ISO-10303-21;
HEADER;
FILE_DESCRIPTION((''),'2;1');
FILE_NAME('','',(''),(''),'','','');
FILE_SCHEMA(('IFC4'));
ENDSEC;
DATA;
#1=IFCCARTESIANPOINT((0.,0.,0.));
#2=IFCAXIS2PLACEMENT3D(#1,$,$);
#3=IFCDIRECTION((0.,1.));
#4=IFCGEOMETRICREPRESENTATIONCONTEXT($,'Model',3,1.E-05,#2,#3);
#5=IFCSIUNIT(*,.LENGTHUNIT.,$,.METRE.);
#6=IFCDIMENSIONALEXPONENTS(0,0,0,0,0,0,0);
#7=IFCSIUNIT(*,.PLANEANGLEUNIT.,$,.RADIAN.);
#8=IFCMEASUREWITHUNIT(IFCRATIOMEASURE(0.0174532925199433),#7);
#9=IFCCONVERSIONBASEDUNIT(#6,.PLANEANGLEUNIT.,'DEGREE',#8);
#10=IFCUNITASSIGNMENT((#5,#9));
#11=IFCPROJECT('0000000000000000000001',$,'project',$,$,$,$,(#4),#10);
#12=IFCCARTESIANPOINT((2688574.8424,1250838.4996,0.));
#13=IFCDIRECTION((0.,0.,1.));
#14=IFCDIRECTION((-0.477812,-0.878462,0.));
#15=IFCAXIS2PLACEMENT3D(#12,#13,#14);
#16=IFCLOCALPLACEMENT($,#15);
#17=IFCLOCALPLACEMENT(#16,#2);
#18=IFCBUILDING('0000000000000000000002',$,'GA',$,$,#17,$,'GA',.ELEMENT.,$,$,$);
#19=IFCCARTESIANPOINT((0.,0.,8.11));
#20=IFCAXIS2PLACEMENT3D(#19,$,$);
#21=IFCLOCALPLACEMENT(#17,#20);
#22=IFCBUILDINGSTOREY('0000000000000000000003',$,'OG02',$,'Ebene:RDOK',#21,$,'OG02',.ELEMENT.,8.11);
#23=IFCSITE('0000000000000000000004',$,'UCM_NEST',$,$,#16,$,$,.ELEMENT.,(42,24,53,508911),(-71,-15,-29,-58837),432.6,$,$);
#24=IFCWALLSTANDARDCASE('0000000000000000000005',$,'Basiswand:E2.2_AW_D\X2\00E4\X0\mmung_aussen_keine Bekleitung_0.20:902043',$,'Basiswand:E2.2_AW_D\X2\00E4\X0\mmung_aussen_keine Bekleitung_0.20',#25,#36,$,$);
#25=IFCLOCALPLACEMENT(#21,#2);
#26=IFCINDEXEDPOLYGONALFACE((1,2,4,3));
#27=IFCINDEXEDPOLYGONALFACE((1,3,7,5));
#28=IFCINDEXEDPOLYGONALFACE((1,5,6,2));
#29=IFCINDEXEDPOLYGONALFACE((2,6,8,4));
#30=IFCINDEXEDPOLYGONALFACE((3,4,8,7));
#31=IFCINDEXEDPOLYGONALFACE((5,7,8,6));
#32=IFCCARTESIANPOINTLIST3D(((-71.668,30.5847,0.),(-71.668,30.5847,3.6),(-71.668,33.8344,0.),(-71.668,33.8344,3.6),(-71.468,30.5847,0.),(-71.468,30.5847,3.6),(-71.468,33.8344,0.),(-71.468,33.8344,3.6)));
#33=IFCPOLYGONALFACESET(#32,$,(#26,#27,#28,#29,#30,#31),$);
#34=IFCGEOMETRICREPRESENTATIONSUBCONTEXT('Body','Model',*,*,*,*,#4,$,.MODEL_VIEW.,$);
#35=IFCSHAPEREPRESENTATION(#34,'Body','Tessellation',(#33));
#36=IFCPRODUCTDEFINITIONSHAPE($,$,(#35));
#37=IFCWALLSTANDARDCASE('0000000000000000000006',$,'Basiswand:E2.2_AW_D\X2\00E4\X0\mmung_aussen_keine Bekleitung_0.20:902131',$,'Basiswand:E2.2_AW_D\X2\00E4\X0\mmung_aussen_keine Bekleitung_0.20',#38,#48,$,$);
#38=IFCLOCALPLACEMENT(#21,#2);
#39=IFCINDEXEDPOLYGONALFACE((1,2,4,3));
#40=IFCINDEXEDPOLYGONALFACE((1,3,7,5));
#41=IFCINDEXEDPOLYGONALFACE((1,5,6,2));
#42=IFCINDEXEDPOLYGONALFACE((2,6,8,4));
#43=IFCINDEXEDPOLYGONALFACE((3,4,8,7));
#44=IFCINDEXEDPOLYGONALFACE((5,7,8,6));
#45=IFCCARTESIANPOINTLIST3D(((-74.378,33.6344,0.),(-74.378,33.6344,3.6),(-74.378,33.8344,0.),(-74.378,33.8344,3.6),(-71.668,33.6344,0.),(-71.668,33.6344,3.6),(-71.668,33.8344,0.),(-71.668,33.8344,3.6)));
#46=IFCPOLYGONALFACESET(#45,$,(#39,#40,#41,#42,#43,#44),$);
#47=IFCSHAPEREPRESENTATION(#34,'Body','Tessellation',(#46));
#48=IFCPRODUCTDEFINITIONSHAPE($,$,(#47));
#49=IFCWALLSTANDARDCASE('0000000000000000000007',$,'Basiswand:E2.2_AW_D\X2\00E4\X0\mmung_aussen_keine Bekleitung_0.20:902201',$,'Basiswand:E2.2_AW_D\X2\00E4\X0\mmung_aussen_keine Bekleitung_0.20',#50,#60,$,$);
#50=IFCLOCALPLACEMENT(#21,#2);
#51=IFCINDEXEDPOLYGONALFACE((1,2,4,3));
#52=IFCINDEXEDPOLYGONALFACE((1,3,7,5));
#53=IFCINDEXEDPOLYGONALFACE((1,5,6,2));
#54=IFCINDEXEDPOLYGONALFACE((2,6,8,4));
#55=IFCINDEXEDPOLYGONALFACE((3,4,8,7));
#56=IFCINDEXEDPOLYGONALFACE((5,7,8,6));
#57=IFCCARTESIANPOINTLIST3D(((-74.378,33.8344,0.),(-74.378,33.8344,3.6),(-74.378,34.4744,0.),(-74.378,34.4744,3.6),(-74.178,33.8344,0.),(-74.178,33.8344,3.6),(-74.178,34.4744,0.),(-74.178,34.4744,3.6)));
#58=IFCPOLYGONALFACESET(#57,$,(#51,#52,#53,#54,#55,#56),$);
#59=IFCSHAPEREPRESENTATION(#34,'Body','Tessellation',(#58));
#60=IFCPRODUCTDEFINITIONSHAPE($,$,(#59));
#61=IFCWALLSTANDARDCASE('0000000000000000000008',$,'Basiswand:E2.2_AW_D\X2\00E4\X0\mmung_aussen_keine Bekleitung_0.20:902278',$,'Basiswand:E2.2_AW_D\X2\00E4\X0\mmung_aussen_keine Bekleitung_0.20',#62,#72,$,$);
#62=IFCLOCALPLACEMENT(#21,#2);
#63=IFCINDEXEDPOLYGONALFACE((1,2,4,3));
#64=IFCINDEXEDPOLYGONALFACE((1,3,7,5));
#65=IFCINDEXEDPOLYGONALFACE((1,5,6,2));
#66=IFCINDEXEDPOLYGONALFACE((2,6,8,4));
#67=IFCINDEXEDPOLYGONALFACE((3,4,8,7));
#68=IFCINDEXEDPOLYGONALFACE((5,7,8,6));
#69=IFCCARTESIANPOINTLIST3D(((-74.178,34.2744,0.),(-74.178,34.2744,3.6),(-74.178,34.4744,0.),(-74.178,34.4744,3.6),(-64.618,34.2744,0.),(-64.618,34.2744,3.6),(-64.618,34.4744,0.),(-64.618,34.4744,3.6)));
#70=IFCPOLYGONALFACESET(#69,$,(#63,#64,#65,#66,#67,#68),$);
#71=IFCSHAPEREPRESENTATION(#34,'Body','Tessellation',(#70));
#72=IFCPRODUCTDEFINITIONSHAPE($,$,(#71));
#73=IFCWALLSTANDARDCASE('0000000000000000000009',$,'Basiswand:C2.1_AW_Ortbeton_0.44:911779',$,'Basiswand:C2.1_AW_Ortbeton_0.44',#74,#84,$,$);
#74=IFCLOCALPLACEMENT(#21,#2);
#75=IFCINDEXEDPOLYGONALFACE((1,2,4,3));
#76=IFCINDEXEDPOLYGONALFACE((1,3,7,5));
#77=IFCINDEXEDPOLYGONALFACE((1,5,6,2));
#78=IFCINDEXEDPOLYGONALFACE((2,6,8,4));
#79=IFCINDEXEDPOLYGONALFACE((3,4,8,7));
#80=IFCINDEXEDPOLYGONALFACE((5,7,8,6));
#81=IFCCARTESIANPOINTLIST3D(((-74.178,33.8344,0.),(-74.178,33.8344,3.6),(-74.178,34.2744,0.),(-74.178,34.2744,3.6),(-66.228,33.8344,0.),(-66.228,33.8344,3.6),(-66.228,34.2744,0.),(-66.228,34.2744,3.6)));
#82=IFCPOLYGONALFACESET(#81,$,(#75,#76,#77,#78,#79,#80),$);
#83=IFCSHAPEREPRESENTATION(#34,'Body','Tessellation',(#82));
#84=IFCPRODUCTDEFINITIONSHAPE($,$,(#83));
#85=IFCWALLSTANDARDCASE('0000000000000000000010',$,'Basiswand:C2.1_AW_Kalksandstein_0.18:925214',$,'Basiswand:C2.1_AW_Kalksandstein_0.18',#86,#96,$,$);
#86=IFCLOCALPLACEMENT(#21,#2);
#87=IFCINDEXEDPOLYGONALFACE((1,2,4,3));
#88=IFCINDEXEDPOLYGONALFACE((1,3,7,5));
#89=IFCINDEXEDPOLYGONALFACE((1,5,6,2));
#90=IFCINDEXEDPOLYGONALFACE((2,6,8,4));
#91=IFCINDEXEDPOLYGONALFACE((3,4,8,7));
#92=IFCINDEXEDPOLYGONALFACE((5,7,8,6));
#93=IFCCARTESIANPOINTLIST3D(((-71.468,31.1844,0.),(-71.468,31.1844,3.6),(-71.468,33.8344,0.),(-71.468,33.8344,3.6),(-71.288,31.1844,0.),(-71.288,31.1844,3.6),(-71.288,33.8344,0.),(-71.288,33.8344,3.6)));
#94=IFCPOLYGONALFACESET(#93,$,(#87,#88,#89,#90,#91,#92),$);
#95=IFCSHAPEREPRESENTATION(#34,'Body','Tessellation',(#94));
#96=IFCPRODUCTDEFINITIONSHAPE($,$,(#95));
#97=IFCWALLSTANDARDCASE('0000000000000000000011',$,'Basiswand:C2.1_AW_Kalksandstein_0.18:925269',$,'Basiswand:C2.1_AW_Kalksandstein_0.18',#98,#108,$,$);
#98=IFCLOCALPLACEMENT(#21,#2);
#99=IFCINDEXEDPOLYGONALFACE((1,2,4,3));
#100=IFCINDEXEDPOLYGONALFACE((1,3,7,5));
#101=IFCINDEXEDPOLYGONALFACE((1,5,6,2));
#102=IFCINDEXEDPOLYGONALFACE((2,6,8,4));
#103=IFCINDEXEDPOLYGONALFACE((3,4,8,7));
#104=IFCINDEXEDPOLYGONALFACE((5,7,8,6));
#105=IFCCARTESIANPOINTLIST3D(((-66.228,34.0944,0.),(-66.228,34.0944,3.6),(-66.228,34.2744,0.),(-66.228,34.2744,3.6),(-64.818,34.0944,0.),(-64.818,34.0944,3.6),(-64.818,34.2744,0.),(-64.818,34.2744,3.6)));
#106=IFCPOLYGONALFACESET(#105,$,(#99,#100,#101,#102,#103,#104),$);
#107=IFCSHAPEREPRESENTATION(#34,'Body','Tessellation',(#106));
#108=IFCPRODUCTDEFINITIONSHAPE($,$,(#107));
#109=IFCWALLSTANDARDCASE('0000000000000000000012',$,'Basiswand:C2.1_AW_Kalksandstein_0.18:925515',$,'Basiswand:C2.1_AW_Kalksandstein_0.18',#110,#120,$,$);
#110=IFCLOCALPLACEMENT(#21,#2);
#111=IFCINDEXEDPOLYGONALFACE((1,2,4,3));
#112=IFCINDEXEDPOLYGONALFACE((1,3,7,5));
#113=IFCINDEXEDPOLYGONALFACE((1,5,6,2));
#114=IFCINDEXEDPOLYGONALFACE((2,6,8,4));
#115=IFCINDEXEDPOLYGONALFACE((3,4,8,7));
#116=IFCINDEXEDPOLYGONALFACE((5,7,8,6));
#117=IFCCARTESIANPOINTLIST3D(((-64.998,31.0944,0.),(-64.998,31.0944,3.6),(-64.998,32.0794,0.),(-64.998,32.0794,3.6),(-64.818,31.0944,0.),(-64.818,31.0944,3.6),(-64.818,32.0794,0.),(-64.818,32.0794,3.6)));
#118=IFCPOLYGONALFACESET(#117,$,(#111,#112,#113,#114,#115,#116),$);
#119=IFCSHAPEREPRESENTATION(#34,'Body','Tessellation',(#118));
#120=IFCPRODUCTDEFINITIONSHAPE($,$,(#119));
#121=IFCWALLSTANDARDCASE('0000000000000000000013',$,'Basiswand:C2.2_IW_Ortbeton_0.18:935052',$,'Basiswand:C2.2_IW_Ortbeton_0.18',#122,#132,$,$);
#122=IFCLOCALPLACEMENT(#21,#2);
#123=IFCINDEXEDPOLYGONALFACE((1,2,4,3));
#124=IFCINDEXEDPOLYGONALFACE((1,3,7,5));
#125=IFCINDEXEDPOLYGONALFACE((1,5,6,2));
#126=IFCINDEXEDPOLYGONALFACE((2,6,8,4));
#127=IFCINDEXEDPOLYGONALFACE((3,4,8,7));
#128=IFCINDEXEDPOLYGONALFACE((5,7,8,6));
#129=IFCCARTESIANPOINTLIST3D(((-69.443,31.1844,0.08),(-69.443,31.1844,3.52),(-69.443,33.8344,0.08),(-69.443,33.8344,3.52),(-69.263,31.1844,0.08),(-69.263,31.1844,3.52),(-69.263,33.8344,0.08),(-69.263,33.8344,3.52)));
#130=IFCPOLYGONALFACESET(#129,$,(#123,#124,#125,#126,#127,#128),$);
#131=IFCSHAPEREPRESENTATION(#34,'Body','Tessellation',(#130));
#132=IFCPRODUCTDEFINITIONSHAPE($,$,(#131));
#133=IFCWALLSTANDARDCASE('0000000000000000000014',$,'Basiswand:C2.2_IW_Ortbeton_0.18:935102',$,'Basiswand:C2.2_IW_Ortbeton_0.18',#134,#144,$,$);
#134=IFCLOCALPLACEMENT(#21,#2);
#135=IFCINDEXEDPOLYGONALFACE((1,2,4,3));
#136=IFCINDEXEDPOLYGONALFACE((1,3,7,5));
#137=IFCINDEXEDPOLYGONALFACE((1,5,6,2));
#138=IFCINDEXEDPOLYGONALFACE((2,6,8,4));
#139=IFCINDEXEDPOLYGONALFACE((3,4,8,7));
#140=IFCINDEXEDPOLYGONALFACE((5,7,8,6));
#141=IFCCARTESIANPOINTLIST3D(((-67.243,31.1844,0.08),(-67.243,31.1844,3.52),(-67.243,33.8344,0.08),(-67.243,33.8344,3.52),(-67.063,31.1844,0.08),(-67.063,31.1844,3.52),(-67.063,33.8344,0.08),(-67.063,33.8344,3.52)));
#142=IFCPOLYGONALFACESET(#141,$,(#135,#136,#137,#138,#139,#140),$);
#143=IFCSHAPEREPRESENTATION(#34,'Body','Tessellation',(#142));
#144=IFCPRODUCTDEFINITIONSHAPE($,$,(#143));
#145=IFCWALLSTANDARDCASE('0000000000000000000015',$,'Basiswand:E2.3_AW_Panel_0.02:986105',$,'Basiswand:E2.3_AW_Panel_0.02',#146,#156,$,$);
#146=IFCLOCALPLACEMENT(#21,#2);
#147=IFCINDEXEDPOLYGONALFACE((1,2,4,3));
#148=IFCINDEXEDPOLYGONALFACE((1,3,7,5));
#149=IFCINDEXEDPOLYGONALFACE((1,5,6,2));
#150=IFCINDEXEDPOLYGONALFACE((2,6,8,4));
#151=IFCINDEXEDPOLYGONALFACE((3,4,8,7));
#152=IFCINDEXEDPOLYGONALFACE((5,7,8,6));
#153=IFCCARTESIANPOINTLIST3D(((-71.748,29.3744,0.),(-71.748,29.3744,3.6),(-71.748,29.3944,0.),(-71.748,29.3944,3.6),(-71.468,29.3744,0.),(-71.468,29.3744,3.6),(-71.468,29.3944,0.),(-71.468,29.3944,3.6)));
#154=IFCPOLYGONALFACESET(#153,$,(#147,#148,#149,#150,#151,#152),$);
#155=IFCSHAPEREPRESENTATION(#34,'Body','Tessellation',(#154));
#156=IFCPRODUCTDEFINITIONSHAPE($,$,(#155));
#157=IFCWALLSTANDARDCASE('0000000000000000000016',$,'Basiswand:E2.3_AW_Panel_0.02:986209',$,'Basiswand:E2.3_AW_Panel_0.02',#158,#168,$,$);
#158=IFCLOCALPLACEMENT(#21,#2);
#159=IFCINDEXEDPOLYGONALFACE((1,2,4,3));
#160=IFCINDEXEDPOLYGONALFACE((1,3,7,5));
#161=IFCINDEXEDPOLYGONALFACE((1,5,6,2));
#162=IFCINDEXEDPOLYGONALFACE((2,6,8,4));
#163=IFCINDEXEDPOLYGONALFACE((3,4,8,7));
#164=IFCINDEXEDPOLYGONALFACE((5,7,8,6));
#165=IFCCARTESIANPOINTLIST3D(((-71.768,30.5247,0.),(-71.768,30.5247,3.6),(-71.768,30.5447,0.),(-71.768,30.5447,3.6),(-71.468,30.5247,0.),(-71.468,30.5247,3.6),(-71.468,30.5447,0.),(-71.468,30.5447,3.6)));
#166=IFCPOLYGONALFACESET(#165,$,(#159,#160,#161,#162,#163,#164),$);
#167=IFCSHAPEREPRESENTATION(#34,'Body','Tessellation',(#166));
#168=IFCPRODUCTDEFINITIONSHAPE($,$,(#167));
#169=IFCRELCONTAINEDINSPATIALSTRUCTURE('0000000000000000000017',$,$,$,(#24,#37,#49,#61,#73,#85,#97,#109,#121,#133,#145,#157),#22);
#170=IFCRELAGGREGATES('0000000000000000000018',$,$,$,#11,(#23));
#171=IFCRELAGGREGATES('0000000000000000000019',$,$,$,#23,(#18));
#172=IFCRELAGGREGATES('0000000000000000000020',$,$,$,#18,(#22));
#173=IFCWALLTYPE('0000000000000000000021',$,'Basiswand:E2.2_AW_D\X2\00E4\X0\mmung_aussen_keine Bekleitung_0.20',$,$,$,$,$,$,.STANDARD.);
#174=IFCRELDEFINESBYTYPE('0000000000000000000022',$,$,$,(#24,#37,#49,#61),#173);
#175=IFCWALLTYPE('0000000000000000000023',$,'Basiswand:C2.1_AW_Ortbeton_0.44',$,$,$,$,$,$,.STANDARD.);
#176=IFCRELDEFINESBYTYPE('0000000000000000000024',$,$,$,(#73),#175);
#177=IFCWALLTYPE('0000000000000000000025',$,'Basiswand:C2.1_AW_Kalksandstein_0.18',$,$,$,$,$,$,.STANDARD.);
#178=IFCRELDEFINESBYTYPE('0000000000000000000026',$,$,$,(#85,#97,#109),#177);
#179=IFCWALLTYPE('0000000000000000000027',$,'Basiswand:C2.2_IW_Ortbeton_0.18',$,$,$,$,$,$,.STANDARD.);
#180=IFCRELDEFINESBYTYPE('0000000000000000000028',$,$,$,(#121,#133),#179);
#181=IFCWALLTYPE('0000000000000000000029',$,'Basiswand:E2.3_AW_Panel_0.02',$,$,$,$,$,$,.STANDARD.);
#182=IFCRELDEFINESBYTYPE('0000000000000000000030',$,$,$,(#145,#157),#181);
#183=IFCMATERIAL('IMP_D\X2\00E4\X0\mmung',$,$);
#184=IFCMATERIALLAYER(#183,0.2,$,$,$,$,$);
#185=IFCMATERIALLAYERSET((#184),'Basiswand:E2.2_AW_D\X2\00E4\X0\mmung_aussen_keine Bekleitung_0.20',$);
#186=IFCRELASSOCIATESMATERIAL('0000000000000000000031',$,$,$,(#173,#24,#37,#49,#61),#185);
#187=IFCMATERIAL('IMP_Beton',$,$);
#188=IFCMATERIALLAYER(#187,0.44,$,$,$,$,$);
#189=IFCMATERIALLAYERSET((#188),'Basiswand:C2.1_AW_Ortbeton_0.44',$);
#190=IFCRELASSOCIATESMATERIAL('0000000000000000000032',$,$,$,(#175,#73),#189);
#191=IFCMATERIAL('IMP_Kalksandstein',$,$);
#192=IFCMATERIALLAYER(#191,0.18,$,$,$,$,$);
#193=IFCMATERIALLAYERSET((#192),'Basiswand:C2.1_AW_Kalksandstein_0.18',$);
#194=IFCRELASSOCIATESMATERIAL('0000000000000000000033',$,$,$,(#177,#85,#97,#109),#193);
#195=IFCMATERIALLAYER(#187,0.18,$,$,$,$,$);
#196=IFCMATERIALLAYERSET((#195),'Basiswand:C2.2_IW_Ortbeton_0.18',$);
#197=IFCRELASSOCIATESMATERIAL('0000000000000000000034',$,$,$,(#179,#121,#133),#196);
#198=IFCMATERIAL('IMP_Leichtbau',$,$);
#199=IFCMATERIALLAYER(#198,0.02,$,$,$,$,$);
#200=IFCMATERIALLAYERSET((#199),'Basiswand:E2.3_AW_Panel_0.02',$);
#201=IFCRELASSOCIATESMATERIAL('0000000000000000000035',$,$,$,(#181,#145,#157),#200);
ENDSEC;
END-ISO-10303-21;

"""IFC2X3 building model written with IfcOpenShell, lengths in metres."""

from ifc_helpers import new_model, entity, si_unit, converted_unit, direction, frame, frame_2d, origin, place, context, subcontext, project, spatial, polyline, rectangle, extrude, clip, bounded_halfspace, material, layer, layer_set, layer_usage, type_object, element, save


model = new_model("IFC2X3")

# Units and contexts
model_context = context("Model", 3, precision=1e-05, world=origin(), true_north=direction((0.0, 1.0)))
body_context = subcontext(model_context, "Body", "Model", "MODEL_VIEW")
ifc_project = project(units=[si_unit("LENGTHUNIT", "METRE"), converted_unit("PLANEANGLEUNIT", "DEGREE", entity("IfcRatioMeasure", 0.0174532925199433), si_unit("PLANEANGLEUNIT", "RADIAN"), dimensions=[0, 0, 0, 0, 0, 0, 0])], contexts=[model_context])

# Site, building, storey
site_placement = place(None, frame((2688574.8424, 1250838.4996, 0.0), z_axis=(0.0, 0.0, 1.0), x_axis=(-0.477812, -0.878462, 0.0)))
site = spatial("IfcSite", under=ifc_project, at=site_placement, Name="UCM_NEST", CompositionType="ELEMENT", RefLatitude=(42, 24, 53, 508911), RefLongitude=(-71, -15, -29, -58837), RefElevation=432.6)
building_placement = place(site_placement, origin())
building = spatial("IfcBuilding", under=site, at=building_placement, Name="GA", LongName="GA", CompositionType="ELEMENT")
storey_placement = place(building_placement, frame((0.0, 0.0, 8.11)))
storey = spatial("IfcBuildingStorey", under=building, at=storey_placement, Name="OG02", ObjectType="Ebene:RDOK", LongName="OG02", CompositionType="ELEMENT", Elevation=8.11)

# Walls
ifc_material_1 = material(Name="IMP_Dämmung")
ifc_layer_1 = layer(ifc_material_1, 0.2)
ifc_layer_set_1 = layer_set([ifc_layer_1], Name="Basiswand:E2.2_AW_Dämmung_aussen_keine Bekleitung_0.20")
ifc_layer_usage_1 = layer_usage(ifc_layer_set_1, "AXIS2", "NEGATIVE", 0.1)
wall_type_1 = type_object("IfcWallType", Name="Basiswand:E2.2_AW_Dämmung_aussen_keine Bekleitung_0.20", PredefinedType="STANDARD", material=ifc_layer_set_1)
wall_1_placement = place(storey_placement, frame((-71.568, 30.5847, 0.0), z_axis=(0.0, 0.0, 1.0), x_axis=(0.0, 1.0, 0.0)))
element("IfcWallStandardCase", 1, at=wall_1_placement, inside=storey, type_object=wall_type_1, material=ifc_layer_usage_1, Name="Basiswand:E2.2_AW_Dämmung_aussen_keine Bekleitung_0.20:902043", ObjectType="Basiswand:E2.2_AW_Dämmung_aussen_keine Bekleitung_0.20", context=body_context, shape_type="SweptSolid", body=[
    extrude(rectangle(XDim=3.2498, YDim=0.2, at=frame_2d((1.6249, 0.0), x_axis=(-1.0, 0.0))), origin(), (0.0, 0.0, 1.0), 3.6),
])
ifc_layer_usage_2 = layer_usage(ifc_layer_set_1, "AXIS2", "NEGATIVE", 0.1)
wall_2_placement = place(storey_placement, frame((-71.668, 33.7344, 0.0), z_axis=(0.0, 0.0, 1.0), x_axis=(-1.0, 0.0, 0.0)))
element("IfcWallStandardCase", 2, at=wall_2_placement, inside=storey, type_object=wall_type_1, material=ifc_layer_usage_2, Name="Basiswand:E2.2_AW_Dämmung_aussen_keine Bekleitung_0.20:902131", ObjectType="Basiswand:E2.2_AW_Dämmung_aussen_keine Bekleitung_0.20", context=body_context, shape_type="SweptSolid", body=[
    extrude(rectangle(XDim=2.71, YDim=0.2, at=frame_2d((1.355, 0.0), x_axis=(-1.0, 0.0))), origin(), (0.0, 0.0, 1.0), 3.6),
])
ifc_layer_usage_3 = layer_usage(ifc_layer_set_1, "AXIS2", "NEGATIVE", 0.1)
wall_3_placement = place(storey_placement, frame((-74.278, 33.8344, 0.0), z_axis=(0.0, 0.0, 1.0), x_axis=(0.0, 1.0, 0.0)))
element("IfcWallStandardCase", 3, at=wall_3_placement, inside=storey, type_object=wall_type_1, material=ifc_layer_usage_3, Name="Basiswand:E2.2_AW_Dämmung_aussen_keine Bekleitung_0.20:902201", ObjectType="Basiswand:E2.2_AW_Dämmung_aussen_keine Bekleitung_0.20", context=body_context, shape_type="SweptSolid", body=[
    extrude(rectangle(XDim=0.64, YDim=0.2, at=frame_2d((0.32, 0.0), x_axis=(-1.0, 0.0))), origin(), (0.0, 0.0, 1.0), 3.6),
])
ifc_layer_usage_4 = layer_usage(ifc_layer_set_1, "AXIS2", "NEGATIVE", 0.1)
wall_4_placement = place(storey_placement, frame((-74.178, 34.3744, 0.0)))
element("IfcWallStandardCase", 4, at=wall_4_placement, inside=storey, type_object=wall_type_1, material=ifc_layer_usage_4, Name="Basiswand:E2.2_AW_Dämmung_aussen_keine Bekleitung_0.20:902278", ObjectType="Basiswand:E2.2_AW_Dämmung_aussen_keine Bekleitung_0.20", context=body_context, shape_type="SweptSolid", body=[
    extrude(rectangle(XDim=9.56, YDim=0.2, at=frame_2d((4.78, 0.0), x_axis=(-1.0, 0.0))), origin(), (0.0, 0.0, 1.0), 3.6),
])
ifc_material_2 = material(Name="IMP_Beton")
ifc_layer_2 = layer(ifc_material_2, 0.44)
ifc_layer_set_2 = layer_set([ifc_layer_2], Name="Basiswand:C2.1_AW_Ortbeton_0.44")
ifc_layer_usage_5 = layer_usage(ifc_layer_set_2, "AXIS2", "NEGATIVE", 0.22)
wall_type_2 = type_object("IfcWallType", Name="Basiswand:C2.1_AW_Ortbeton_0.44", PredefinedType="STANDARD", material=ifc_layer_set_2)
wall_5_placement = place(storey_placement, frame((-74.178, 34.0544, 0.0)))
element("IfcWallStandardCase", 5, at=wall_5_placement, inside=storey, type_object=wall_type_2, material=ifc_layer_usage_5, Name="Basiswand:C2.1_AW_Ortbeton_0.44:911779", ObjectType="Basiswand:C2.1_AW_Ortbeton_0.44", context=body_context, shape_type="SweptSolid", body=[
    extrude(rectangle(XDim=7.95, YDim=0.44, at=frame_2d((3.975, 0.0), x_axis=(-1.0, 0.0))), origin(), (0.0, 0.0, 1.0), 3.6),
])

# Shared definitions
ifc_material_3 = material(Name="IMP_Kalksandstein")
ifc_layer_3 = layer(ifc_material_3, 0.18)
ifc_layer_set_3 = layer_set([ifc_layer_3], Name="Basiswand:C2.1_AW_Kalksandstein_0.18")
wall_type_3 = type_object("IfcWallType", Name="Basiswand:C2.1_AW_Kalksandstein_0.18", PredefinedType="STANDARD", material=ifc_layer_set_3)

# Walls
ifc_layer_usage_6 = layer_usage(ifc_layer_set_3, "AXIS2", "NEGATIVE", 0.09)
wall_6_placement = place(storey_placement, frame((-71.378, 31.1844, 0.0), z_axis=(0.0, 0.0, 1.0), x_axis=(0.0, 1.0, 0.0)))
element("IfcWallStandardCase", 6, at=wall_6_placement, inside=storey, type_object=wall_type_3, material=ifc_layer_usage_6, Name="Basiswand:C2.1_AW_Kalksandstein_0.18:925214", ObjectType="Basiswand:C2.1_AW_Kalksandstein_0.18", context=body_context, shape_type="SweptSolid", body=[
    extrude(rectangle(XDim=2.65, YDim=0.18, at=frame_2d((1.325, 0.0), x_axis=(-1.0, 0.0))), origin(), (0.0, 0.0, 1.0), 3.6),
])
ifc_layer_usage_7 = layer_usage(ifc_layer_set_3, "AXIS2", "NEGATIVE", 0.09)
wall_7_placement = place(storey_placement, frame((-66.228, 34.1844, 0.0)))
element("IfcWallStandardCase", 7, at=wall_7_placement, inside=storey, type_object=wall_type_3, material=ifc_layer_usage_7, Name="Basiswand:C2.1_AW_Kalksandstein_0.18:925269", ObjectType="Basiswand:C2.1_AW_Kalksandstein_0.18", context=body_context, shape_type="SweptSolid", body=[
    extrude(rectangle(XDim=1.41, YDim=0.18, at=frame_2d((0.705, 0.0), x_axis=(-1.0, 0.0))), origin(), (0.0, 0.0, 1.0), 3.6),
])
ifc_layer_usage_8 = layer_usage(ifc_layer_set_3, "AXIS2", "NEGATIVE", 0.09)
wall_8_placement = place(storey_placement, frame((-64.908, 32.0794, 0.0), z_axis=(0.0, 0.0, 1.0), x_axis=(0.0, -1.0, 0.0)))
element("IfcWallStandardCase", 8, at=wall_8_placement, inside=storey, type_object=wall_type_3, material=ifc_layer_usage_8, Name="Basiswand:C2.1_AW_Kalksandstein_0.18:925515", ObjectType="Basiswand:C2.1_AW_Kalksandstein_0.18", context=body_context, shape_type="SweptSolid", body=[
    extrude(rectangle(XDim=0.985, YDim=0.18, at=frame_2d((0.4925, 0.0), x_axis=(-1.0, 0.0))), origin(), (0.0, 0.0, 1.0), 3.6),
])
ifc_layer_4 = layer(ifc_material_2, 0.18)
ifc_layer_set_4 = layer_set([ifc_layer_4], Name="Basiswand:C2.2_IW_Ortbeton_0.18")
ifc_layer_usage_9 = layer_usage(ifc_layer_set_4, "AXIS2", "NEGATIVE", 0.09)
wall_type_4 = type_object("IfcWallType", Name="Basiswand:C2.2_IW_Ortbeton_0.18", PredefinedType="STANDARD", material=ifc_layer_set_4)
wall_9_placement = place(storey_placement, frame((-69.353, 31.1844, 0.08), z_axis=(0.0, 0.0, 1.0), x_axis=(0.0, 1.0, 0.0)))
element("IfcWallStandardCase", 9, at=wall_9_placement, inside=storey, type_object=wall_type_4, material=ifc_layer_usage_9, Name="Basiswand:C2.2_IW_Ortbeton_0.18:935052", ObjectType="Basiswand:C2.2_IW_Ortbeton_0.18", context=body_context, shape_type="Clipping", body=[
    clip(clip(extrude(rectangle(XDim=2.65, YDim=0.18, at=frame_2d((1.325, 0.0), x_axis=(-1.0, 0.0))), origin(), (0.0, 0.0, 1.0), 3.44), bounded_halfspace(frame((2.65, -0.09, 0.0), z_axis=(0.0, 0.0, 1.0), x_axis=(0.0, 1.0, 0.0)), True, frame((2.65, -0.09, 0.0), z_axis=(0.0, 0.0, 1.0), x_axis=(0.0, 1.0, 0.0)), polyline([(0.0, 0.0), (0.18, 0.0), (0.18, 2.65), (0.0, 2.65), (0.0, 0.0)]))), bounded_halfspace(frame((0.0, -0.09, 3.44), z_axis=(0.0, 0.0, -1.0), x_axis=(0.0, 1.0, 0.0)), True, frame((0.0, -0.09, 3.44), z_axis=(0.0, 0.0, -1.0), x_axis=(0.0, 1.0, 0.0)), polyline([(0.0, 0.0), (0.18, 0.0), (0.18, 2.65), (0.0, 2.65), (0.0, 0.0)]))),
])
ifc_layer_usage_10 = layer_usage(ifc_layer_set_4, "AXIS2", "NEGATIVE", 0.09)
wall_10_placement = place(storey_placement, frame((-67.153, 31.1844, 0.08), z_axis=(0.0, 0.0, 1.0), x_axis=(0.0, 1.0, 0.0)))
element("IfcWallStandardCase", 10, at=wall_10_placement, inside=storey, type_object=wall_type_4, material=ifc_layer_usage_10, Name="Basiswand:C2.2_IW_Ortbeton_0.18:935102", ObjectType="Basiswand:C2.2_IW_Ortbeton_0.18", context=body_context, shape_type="Clipping", body=[
    clip(clip(extrude(rectangle(XDim=2.65, YDim=0.18, at=frame_2d((1.325, 0.0), x_axis=(-1.0, 0.0))), origin(), (0.0, 0.0, 1.0), 3.44), bounded_halfspace(frame((2.65, -0.09, 0.0), z_axis=(0.0, 0.0, 1.0), x_axis=(0.0, 1.0, 0.0)), True, frame((2.65, -0.09, 0.0), z_axis=(0.0, 0.0, 1.0), x_axis=(0.0, 1.0, 0.0)), polyline([(0.0, 0.0), (0.18, 0.0), (0.18, 2.65), (0.0, 2.65), (0.0, 0.0)]))), bounded_halfspace(frame((0.0, -0.09, 3.44), z_axis=(0.0, 0.0, -1.0), x_axis=(0.0, 1.0, 0.0)), True, frame((0.0, -0.09, 3.44), z_axis=(0.0, 0.0, -1.0), x_axis=(0.0, 1.0, 0.0)), polyline([(0.0, 0.0), (0.18, 0.0), (0.18, 2.65), (0.0, 2.65), (0.0, 0.0)]))),
])
ifc_material_4 = material(Name="IMP_Leichtbau")
ifc_layer_5 = layer(ifc_material_4, 0.02)
ifc_layer_set_5 = layer_set([ifc_layer_5], Name="Basiswand:E2.3_AW_Panel_0.02")
ifc_layer_usage_11 = layer_usage(ifc_layer_set_5, "AXIS2", "NEGATIVE", 0.01)
wall_type_5 = type_object("IfcWallType", Name="Basiswand:E2.3_AW_Panel_0.02", PredefinedType="STANDARD", material=ifc_layer_set_5)
wall_11_placement = place(storey_placement, frame((-71.748, 29.3844, 0.0)))
element("IfcWallStandardCase", 11, at=wall_11_placement, inside=storey, type_object=wall_type_5, material=ifc_layer_usage_11, Name="Basiswand:E2.3_AW_Panel_0.02:986105", ObjectType="Basiswand:E2.3_AW_Panel_0.02", context=body_context, shape_type="SweptSolid", body=[
    extrude(rectangle(XDim=0.28, YDim=0.02, at=frame_2d((0.14, 0.0), x_axis=(-1.0, 0.0))), origin(), (0.0, 0.0, 1.0), 3.6),
])
ifc_layer_usage_12 = layer_usage(ifc_layer_set_5, "AXIS2", "NEGATIVE", 0.01)
wall_12_placement = place(storey_placement, frame((-71.468, 30.5347, 0.0), z_axis=(0.0, 0.0, 1.0), x_axis=(-1.0, 0.0, 0.0)))
element("IfcWallStandardCase", 12, at=wall_12_placement, inside=storey, type_object=wall_type_5, material=ifc_layer_usage_12, Name="Basiswand:E2.3_AW_Panel_0.02:986209", ObjectType="Basiswand:E2.3_AW_Panel_0.02", context=body_context, shape_type="SweptSolid", body=[
    extrude(rectangle(XDim=0.3, YDim=0.02, at=frame_2d((0.15, 0.0), x_axis=(-1.0, 0.0))), origin(), (0.0, 0.0, 1.0), 3.6),
])

save(model, "model.ifc")
